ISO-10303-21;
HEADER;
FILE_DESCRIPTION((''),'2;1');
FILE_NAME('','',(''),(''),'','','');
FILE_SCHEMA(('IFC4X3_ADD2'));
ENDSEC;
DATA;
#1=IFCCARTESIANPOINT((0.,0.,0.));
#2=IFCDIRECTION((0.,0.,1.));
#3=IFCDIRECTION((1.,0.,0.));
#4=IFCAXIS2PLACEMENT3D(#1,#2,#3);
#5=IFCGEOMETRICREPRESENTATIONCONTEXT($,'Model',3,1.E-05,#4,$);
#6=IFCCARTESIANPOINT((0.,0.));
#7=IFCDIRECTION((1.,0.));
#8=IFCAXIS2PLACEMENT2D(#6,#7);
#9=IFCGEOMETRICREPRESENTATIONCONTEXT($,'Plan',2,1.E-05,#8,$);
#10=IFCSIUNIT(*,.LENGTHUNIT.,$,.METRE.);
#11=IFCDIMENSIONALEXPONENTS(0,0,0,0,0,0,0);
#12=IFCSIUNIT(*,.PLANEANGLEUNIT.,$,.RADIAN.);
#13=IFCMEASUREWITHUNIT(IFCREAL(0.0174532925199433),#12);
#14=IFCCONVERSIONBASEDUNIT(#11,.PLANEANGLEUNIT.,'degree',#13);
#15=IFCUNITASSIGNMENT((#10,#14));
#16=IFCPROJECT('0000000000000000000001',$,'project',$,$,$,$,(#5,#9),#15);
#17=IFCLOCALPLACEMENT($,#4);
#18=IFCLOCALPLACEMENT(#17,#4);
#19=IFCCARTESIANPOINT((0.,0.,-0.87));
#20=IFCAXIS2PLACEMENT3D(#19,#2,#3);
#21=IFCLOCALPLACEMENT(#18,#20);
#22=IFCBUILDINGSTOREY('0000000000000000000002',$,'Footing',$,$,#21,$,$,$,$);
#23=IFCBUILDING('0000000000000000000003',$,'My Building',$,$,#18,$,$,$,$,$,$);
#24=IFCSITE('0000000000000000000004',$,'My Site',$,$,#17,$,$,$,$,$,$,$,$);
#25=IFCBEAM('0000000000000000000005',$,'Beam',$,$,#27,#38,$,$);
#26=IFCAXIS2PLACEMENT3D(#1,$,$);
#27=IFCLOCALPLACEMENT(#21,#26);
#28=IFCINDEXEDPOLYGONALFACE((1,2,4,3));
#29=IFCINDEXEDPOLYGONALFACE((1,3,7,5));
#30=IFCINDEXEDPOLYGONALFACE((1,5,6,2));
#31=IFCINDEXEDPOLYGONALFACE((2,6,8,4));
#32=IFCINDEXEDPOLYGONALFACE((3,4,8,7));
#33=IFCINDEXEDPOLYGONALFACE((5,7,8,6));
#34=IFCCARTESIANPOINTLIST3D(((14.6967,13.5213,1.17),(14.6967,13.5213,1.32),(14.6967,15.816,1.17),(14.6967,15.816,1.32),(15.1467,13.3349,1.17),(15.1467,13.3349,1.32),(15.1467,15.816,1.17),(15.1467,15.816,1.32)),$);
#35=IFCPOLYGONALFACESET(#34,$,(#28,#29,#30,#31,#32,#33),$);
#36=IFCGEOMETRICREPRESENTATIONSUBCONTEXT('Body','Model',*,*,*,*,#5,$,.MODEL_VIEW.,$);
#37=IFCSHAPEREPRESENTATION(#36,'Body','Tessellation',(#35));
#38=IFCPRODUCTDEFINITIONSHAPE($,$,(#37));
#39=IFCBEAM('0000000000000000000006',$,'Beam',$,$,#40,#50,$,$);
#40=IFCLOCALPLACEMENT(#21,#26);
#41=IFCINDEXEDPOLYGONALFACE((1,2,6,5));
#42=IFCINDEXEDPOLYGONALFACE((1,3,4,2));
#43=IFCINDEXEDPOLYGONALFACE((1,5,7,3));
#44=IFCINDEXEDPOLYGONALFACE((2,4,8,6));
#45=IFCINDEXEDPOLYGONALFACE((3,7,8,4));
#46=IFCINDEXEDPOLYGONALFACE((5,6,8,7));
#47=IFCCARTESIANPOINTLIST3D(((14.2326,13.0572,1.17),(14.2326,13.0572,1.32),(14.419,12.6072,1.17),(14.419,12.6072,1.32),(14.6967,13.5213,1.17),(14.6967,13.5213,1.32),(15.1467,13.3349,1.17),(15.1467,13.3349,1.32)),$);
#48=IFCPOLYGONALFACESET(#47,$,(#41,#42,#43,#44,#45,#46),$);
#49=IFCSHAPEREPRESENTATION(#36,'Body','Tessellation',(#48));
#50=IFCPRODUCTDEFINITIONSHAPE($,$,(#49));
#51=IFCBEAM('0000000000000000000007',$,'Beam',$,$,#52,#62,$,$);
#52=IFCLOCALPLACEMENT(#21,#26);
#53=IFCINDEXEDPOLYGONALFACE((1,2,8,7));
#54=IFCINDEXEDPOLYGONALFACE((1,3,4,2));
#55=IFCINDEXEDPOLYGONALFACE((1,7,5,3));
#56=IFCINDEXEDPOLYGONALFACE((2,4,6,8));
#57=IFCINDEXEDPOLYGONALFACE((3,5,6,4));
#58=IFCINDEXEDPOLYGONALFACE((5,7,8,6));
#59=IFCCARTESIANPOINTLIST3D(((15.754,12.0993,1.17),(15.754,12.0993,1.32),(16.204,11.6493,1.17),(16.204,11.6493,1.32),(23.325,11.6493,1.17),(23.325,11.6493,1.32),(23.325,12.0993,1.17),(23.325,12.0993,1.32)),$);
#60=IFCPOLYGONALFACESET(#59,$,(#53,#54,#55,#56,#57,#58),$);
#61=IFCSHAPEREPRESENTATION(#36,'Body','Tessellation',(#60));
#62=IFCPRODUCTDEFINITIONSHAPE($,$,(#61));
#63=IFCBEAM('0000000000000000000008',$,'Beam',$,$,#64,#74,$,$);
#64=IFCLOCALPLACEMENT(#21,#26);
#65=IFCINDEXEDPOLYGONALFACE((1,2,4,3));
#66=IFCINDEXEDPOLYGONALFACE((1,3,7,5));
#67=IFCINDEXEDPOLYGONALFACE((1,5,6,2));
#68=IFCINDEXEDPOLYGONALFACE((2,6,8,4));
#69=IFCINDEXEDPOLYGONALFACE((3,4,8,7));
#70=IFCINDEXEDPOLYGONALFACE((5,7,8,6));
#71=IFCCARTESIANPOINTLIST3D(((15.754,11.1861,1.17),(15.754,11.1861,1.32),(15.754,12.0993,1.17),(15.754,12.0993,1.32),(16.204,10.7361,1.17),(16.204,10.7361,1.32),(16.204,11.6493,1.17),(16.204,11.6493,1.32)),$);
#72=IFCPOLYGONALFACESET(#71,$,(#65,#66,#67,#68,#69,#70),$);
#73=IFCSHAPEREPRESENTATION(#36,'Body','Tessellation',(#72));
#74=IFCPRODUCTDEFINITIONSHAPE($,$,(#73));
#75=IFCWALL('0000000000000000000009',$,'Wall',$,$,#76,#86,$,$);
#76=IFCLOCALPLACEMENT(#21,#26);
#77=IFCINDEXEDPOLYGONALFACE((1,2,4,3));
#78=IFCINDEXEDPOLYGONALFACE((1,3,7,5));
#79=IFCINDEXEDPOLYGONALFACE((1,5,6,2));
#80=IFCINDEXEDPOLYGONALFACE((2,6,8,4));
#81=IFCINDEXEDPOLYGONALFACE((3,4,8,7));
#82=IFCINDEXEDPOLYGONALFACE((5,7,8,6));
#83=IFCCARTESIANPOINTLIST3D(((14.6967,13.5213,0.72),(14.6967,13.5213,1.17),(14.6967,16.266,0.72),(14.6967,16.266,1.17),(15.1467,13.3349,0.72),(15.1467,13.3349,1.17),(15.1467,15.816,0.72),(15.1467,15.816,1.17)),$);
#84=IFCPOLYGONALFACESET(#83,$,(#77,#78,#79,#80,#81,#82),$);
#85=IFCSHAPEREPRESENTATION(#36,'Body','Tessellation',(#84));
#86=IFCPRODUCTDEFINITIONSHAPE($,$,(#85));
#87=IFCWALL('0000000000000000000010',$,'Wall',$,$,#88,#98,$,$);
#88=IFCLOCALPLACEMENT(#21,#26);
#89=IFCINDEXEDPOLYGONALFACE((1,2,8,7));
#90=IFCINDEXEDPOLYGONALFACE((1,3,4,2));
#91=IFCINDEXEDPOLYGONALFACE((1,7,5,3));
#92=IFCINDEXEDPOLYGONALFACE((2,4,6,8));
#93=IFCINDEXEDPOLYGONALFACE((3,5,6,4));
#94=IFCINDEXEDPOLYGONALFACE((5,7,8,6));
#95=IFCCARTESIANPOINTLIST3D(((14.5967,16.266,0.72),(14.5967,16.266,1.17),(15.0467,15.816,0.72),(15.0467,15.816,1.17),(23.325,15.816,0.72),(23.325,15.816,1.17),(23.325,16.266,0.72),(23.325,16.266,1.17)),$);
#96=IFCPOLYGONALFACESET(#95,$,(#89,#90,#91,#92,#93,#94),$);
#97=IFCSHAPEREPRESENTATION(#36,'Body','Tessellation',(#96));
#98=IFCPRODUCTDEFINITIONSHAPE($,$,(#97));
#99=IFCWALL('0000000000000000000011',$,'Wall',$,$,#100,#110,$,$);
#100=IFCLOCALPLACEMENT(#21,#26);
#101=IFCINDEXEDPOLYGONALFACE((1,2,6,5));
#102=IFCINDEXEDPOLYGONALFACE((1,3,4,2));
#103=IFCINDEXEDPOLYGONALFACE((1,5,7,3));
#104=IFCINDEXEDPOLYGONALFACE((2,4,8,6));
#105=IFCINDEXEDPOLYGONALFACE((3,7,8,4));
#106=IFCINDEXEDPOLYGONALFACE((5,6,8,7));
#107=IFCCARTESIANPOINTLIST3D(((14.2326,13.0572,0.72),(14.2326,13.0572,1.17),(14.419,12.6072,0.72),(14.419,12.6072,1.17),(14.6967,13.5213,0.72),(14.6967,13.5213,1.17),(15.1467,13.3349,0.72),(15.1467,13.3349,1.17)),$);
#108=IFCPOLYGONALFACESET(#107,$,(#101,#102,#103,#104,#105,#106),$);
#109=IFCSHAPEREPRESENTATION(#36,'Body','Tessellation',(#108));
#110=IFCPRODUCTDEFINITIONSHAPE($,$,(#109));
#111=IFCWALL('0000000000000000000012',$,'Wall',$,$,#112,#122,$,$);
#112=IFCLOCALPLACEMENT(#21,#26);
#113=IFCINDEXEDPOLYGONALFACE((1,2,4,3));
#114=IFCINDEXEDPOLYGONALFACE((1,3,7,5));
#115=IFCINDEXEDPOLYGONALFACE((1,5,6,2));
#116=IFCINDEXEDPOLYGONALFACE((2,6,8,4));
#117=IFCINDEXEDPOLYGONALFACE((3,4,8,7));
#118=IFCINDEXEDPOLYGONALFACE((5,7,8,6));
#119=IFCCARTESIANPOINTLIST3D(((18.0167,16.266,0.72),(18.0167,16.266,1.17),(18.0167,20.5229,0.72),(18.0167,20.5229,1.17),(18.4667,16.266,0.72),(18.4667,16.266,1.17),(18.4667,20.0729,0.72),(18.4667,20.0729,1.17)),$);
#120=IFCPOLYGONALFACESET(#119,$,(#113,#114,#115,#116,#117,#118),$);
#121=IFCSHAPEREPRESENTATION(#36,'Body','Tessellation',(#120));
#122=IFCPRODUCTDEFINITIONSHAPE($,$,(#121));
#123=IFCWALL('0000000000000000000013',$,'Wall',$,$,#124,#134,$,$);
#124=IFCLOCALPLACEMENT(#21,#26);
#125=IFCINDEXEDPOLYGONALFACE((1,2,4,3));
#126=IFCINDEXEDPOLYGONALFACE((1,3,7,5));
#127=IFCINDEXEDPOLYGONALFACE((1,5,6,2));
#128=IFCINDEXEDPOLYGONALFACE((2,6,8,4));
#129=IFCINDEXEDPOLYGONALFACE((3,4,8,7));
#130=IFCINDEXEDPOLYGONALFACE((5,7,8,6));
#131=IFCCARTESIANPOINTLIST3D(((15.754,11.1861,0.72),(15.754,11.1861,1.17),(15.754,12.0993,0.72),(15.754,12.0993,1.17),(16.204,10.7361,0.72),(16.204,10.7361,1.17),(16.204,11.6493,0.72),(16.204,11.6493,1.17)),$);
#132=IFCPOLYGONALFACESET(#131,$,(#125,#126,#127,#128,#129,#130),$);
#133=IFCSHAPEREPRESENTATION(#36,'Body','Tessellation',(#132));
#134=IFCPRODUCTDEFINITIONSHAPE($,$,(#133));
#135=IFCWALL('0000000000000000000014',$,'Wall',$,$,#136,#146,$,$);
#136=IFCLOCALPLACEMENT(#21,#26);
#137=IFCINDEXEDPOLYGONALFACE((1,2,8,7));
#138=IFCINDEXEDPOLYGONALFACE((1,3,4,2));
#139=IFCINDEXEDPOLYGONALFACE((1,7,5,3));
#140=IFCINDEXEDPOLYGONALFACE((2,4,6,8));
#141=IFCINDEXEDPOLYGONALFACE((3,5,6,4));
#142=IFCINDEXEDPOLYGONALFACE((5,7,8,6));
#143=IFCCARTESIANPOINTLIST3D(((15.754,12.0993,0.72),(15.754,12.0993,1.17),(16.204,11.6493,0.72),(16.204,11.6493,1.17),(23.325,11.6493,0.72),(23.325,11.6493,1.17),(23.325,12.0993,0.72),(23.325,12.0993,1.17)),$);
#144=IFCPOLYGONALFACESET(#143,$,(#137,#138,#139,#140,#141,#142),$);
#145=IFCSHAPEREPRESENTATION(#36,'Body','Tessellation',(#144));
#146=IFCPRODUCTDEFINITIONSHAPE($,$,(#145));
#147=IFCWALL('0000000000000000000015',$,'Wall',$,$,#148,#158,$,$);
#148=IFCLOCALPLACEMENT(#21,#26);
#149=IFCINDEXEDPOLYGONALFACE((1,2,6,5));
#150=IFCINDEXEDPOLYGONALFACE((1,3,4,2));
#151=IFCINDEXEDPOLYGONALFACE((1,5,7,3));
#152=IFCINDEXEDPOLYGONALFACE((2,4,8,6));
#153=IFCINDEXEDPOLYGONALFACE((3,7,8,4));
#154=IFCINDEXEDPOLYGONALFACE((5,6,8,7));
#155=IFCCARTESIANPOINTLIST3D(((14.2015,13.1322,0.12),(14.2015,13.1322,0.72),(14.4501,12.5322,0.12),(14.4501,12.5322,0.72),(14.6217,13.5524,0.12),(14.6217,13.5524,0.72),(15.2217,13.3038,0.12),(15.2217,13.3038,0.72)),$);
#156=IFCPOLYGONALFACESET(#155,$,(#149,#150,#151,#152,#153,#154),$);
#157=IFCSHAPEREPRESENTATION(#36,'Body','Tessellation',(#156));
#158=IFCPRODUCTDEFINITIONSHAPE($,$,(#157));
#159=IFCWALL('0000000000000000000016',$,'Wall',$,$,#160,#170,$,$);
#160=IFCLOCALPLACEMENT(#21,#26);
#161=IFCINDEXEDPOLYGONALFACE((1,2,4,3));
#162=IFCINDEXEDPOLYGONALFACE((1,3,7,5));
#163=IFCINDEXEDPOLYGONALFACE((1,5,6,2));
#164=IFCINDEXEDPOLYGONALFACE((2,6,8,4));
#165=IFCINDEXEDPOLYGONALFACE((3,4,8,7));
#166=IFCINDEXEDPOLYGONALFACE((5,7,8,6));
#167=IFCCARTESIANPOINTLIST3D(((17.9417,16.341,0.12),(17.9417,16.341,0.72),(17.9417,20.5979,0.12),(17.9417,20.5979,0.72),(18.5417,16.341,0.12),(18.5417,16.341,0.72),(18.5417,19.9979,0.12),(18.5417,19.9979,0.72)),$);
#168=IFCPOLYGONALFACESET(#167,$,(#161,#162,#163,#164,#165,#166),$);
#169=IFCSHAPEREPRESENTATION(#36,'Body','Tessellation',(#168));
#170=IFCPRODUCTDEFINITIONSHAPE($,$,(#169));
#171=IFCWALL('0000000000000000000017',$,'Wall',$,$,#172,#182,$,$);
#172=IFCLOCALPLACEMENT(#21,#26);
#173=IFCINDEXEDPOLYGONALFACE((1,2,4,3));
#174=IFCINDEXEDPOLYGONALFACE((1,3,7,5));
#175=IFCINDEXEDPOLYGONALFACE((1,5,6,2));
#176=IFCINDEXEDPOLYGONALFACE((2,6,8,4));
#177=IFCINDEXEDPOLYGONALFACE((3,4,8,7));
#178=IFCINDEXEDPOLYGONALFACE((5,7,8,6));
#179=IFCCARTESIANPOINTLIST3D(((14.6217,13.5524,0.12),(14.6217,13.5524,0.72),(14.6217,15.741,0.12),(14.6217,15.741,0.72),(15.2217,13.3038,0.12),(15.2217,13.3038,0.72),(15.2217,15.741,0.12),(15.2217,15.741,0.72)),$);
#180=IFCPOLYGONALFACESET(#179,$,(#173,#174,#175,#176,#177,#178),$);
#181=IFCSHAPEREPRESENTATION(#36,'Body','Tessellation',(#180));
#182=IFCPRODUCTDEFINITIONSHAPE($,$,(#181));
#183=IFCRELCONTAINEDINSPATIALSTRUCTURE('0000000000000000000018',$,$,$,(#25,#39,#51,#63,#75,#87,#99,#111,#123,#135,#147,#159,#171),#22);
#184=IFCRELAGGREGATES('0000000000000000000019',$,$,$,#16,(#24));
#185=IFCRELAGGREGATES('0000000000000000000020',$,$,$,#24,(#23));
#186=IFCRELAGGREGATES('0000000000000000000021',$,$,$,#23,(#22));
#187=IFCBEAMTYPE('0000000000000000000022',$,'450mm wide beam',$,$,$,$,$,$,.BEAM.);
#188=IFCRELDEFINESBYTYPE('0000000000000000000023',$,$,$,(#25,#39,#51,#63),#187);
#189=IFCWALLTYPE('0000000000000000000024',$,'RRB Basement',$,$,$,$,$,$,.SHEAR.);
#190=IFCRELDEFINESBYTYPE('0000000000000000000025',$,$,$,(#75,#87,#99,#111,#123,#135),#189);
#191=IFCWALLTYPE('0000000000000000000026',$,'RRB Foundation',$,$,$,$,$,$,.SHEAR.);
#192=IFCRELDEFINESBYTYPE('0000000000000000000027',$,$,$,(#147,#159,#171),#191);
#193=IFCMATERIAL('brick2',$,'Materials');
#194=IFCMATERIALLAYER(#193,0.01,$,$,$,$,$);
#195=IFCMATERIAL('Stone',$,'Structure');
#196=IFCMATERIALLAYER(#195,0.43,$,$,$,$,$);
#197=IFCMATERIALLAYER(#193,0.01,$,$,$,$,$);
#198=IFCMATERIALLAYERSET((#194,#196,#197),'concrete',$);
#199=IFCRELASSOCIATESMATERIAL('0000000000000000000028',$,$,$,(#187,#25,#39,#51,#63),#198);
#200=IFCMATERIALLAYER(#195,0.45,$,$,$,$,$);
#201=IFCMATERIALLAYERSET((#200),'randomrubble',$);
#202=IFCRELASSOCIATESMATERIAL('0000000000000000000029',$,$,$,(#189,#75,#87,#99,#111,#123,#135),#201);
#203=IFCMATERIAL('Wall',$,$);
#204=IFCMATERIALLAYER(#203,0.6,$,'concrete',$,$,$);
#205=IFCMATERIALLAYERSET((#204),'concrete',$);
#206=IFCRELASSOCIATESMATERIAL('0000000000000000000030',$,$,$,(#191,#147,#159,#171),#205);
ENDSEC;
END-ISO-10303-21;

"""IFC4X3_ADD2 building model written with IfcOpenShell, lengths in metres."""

from ifc_helpers import new_model, entity, si_unit, converted_unit, frame, origin_with_axes, origin_2d_with_axis, place, context, subcontext, project, spatial, line, indexed_curve, outline, extrude, material, layer, layer_set, layer_usage, type_object, element, save


model = new_model("IFC4X3_ADD2")

# Units and contexts
model_context = context("Model", 3, precision=1e-05, world=origin_with_axes())
plan_context = context("Plan", 2, precision=1e-05, world=origin_2d_with_axis())
body_context = subcontext(model_context, "Body", "Model", "MODEL_VIEW")
ifc_project = project(units=[si_unit("LENGTHUNIT", "METRE"), converted_unit("PLANEANGLEUNIT", "degree", entity("IfcReal", 0.0174532925199433), si_unit("PLANEANGLEUNIT", "RADIAN"), dimensions=[0, 0, 0, 0, 0, 0, 0])], contexts=[model_context, plan_context])

# Site, building, storey
site_placement = place(None, origin_with_axes())
site = spatial("IfcSite", under=ifc_project, at=site_placement, Name="My Site")
building_placement = place(site_placement, origin_with_axes())
building = spatial("IfcBuilding", under=site, at=building_placement, Name="My Building")
storey_placement = place(building_placement, frame((0.0, 0.0, -0.87), z_axis=(0.0, 0.0, 1.0), x_axis=(1.0, 0.0, 0.0)))
storey = spatial("IfcBuildingStorey", under=building, at=storey_placement, Name="Footing")

# Beams
ifc_material_1 = material(Name="brick2", Category="Materials")
ifc_layer_1 = layer(ifc_material_1, 0.01)
ifc_material_2 = material(Name="Stone", Category="Structure")
ifc_layer_2 = layer(ifc_material_2, 0.43)
ifc_layer_3 = layer(ifc_material_1, 0.01)
ifc_layer_set_1 = layer_set([ifc_layer_1, ifc_layer_2, ifc_layer_3], Name="concrete")
ifc_layer_usage_1 = layer_usage(ifc_layer_set_1, "AXIS2", "POSITIVE", 0.0)
beam_type = type_object("IfcBeamType", Name="450mm wide beam", PredefinedType="BEAM", material=ifc_layer_set_1)
beam_1_placement = place(storey_placement, frame((14.6967, 15.816, 1.17), z_axis=(0.0, 0.0, 1.0), x_axis=(0.0, -1.0, 0.0)))
element("IfcBeam", 1, at=beam_1_placement, inside=storey, type_object=beam_type, material=ifc_layer_usage_1, Name="Beam", context=body_context, shape_type="SweptSolid", body=[
    extrude(outline(indexed_curve([(0.0, 0.0), (0.0, 0.45), (2.4811, 0.45), (2.2947, 0.0)], segments=[line(1, 2, 3, 4, 1)])), origin_with_axes(), (0.0, 0.0, 1.0), 0.15),
])
ifc_layer_usage_2 = layer_usage(ifc_layer_set_1, "AXIS2", "POSITIVE", 0.0)
beam_2_placement = place(storey_placement, frame((14.6967, 13.5213, 1.17), z_axis=(0.0, 0.0, 1.0), x_axis=(-0.707107, -0.707107, 0.0)))
element("IfcBeam", 2, at=beam_2_placement, inside=storey, type_object=beam_type, material=ifc_layer_usage_2, Name="Beam", context=body_context, shape_type="SweptSolid", body=[
    extrude(outline(indexed_curve([(0.0, 0.0), (-0.1864, 0.45), (0.8427, 0.45), (0.6563, 0.0)], segments=[line(1, 2, 3, 4, 1)])), origin_with_axes(), (0.0, 0.0, 1.0), 0.15),
])
ifc_layer_usage_3 = layer_usage(ifc_layer_set_1, "AXIS2", "POSITIVE", 0.0)
beam_3_placement = place(storey_placement, frame((15.754, 11.6493, 1.17), z_axis=(0.0, 0.0, 1.0), x_axis=(1.0, 0.0, 0.0)))
element("IfcBeam", 3, at=beam_3_placement, inside=storey, type_object=beam_type, material=ifc_layer_usage_3, Name="Beam", context=body_context, shape_type="SweptSolid", body=[
    extrude(outline(indexed_curve([(0.45, 0.0), (0.0, 0.45), (7.571, 0.45), (7.571, 0.0)], segments=[line(1, 2, 3, 4, 1)])), origin_with_axes(), (0.0, 0.0, 1.0), 0.15),
])
ifc_layer_usage_4 = layer_usage(ifc_layer_set_1, "AXIS2", "POSITIVE", 0.0)
beam_4_placement = place(storey_placement, frame((15.754, 11.6493, 1.17), z_axis=(0.0, 0.0, 1.0), x_axis=(0.0, -1.0, 0.0)))
element("IfcBeam", 4, at=beam_4_placement, inside=storey, type_object=beam_type, material=ifc_layer_usage_4, Name="Beam", context=body_context, shape_type="SweptSolid", body=[
    extrude(outline(indexed_curve([(-0.45, 0.0), (0.0, 0.45), (0.9132, 0.45), (0.4632, 0.0)], segments=[line(1, 2, 3, 4, 1)])), origin_with_axes(), (0.0, 0.0, 1.0), 0.15),
])

# Walls
ifc_layer_4 = layer(ifc_material_2, 0.45)
ifc_layer_set_2 = layer_set([ifc_layer_4], Name="randomrubble")
ifc_layer_usage_5 = layer_usage(ifc_layer_set_2, "AXIS2", "POSITIVE", 0.0)
wall_type_1 = type_object("IfcWallType", Name="RRB Basement", PredefinedType="SHEAR", material=ifc_layer_set_2)
wall_1_placement = place(storey_placement, frame((15.1467, 13.3349, 0.72), z_axis=(0.0, 0.0, 1.0), x_axis=(0.0, 1.0, 0.0)))
element("IfcWall", 5, at=wall_1_placement, inside=storey, type_object=wall_type_1, material=ifc_layer_usage_5, Name="Wall", context=body_context, shape_type="SweptSolid", body=[
    extrude(outline(indexed_curve([(0.0, 0.0), (0.1864, 0.45), (2.9311, 0.45), (2.4811, 0.0)], segments=[line(1, 2, 3, 4, 1)])), origin_with_axes(), (0.0, 0.0, 1.0), 0.45),
])
ifc_layer_usage_6 = layer_usage(ifc_layer_set_2, "AXIS2", "POSITIVE", 0.0)
wall_2_placement = place(storey_placement, frame((15.0467, 15.816, 0.72), z_axis=(0.0, 0.0, 1.0), x_axis=(1.0, -0.000001, 0.0)))
element("IfcWall", 6, at=wall_2_placement, inside=storey, type_object=wall_type_1, material=ifc_layer_usage_6, Name="Wall", context=body_context, shape_type="SweptSolid", body=[
    extrude(outline(indexed_curve([(0.0, 0.0), (-0.45, 0.45), (8.2783, 0.45), (8.2783, 0.0)], segments=[line(1, 2, 3, 4, 1)])), origin_with_axes(), (0.0, 0.0, 1.0), 0.45),
])
ifc_layer_usage_7 = layer_usage(ifc_layer_set_2, "AXIS2", "POSITIVE", 0.0)
wall_3_placement = place(storey_placement, frame((14.419, 12.6072, 0.72), z_axis=(0.0, 0.0, 1.0), x_axis=(0.707107, 0.707107, 0.0)))
element("IfcWall", 7, at=wall_3_placement, inside=storey, type_object=wall_type_1, material=ifc_layer_usage_7, Name="Wall", context=body_context, shape_type="SweptSolid", body=[
    extrude(outline(indexed_curve([(0.0, 0.0), (0.1864, 0.45), (0.8427, 0.45), (1.0291, 0.0)], segments=[line(1, 2, 3, 4, 1)])), origin_with_axes(), (0.0, 0.0, 1.0), 0.45),
])
ifc_layer_usage_8 = layer_usage(ifc_layer_set_2, "AXIS2", "POSITIVE", 0.0)
wall_4_placement = place(storey_placement, frame((18.4667, 15.816, 0.72), z_axis=(0.0, 0.0, 1.0), x_axis=(0.0, 1.0, 0.0)))
element("IfcWall", 8, at=wall_4_placement, inside=storey, type_object=wall_type_1, material=ifc_layer_usage_8, Name="Wall", context=body_context, shape_type="SweptSolid", body=[
    extrude(outline(indexed_curve([(0.45, 0.0), (0.45, 0.45), (4.7069, 0.45), (4.2569, 0.0)], segments=[line(1, 2, 3, 4, 1)])), origin_with_axes(), (0.0, 0.0, 1.0), 0.45),
])
ifc_layer_usage_9 = layer_usage(ifc_layer_set_2, "AXIS2", "POSITIVE", 0.0)
wall_5_placement = place(storey_placement, frame((16.204, 10.7361, 0.72), z_axis=(0.0, 0.0, 1.0), x_axis=(0.000001, 1.0, 0.0)))
element("IfcWall", 9, at=wall_5_placement, inside=storey, type_object=wall_type_1, material=ifc_layer_usage_9, Name="Wall", context=body_context, shape_type="SweptSolid", body=[
    extrude(outline(indexed_curve([(0.0, 0.0), (0.45, 0.45), (1.3632, 0.45), (0.9132, 0.0)], segments=[line(1, 2, 3, 4, 1)])), origin_with_axes(), (0.0, 0.0, 1.0), 0.45),
])
ifc_layer_usage_10 = layer_usage(ifc_layer_set_2, "AXIS2", "POSITIVE", 0.0)
wall_6_placement = place(storey_placement, frame((16.204, 11.6493, 0.72), z_axis=(0.0, 0.0, 1.0), x_axis=(1.0, -0.000001, 0.0)))
element("IfcWall", 10, at=wall_6_placement, inside=storey, type_object=wall_type_1, material=ifc_layer_usage_10, Name="Wall", context=body_context, shape_type="SweptSolid", body=[
    extrude(outline(indexed_curve([(0.0, 0.0), (-0.45, 0.45), (7.121, 0.45), (7.121, 0.0)], segments=[line(1, 2, 3, 4, 1)])), origin_with_axes(), (0.0, 0.0, 1.0), 0.45),
])
ifc_material_3 = material(Name="Wall")
ifc_layer_5 = layer(ifc_material_3, 0.6, Name="concrete")
ifc_layer_set_3 = layer_set([ifc_layer_5], Name="concrete")
ifc_layer_usage_11 = layer_usage(ifc_layer_set_3, "AXIS2", "POSITIVE", 0.0)
wall_type_2 = type_object("IfcWallType", Name="RRB Foundation", PredefinedType="SHEAR", material=ifc_layer_set_3)
wall_7_placement = place(storey_placement, frame((14.4501, 12.5322, 0.12), z_axis=(0.0, 0.0, 1.0), x_axis=(0.707107, 0.707107, 0.0)))
element("IfcWall", 11, at=wall_7_placement, inside=storey, type_object=wall_type_2, material=ifc_layer_usage_11, Name="Wall", context=body_context, shape_type="SweptSolid", body=[
    extrude(outline(indexed_curve([(0.0, 0.0), (0.2485, 0.6), (0.8427, 0.6), (1.0912, 0.0)], segments=[line(1, 2, 3, 4, 1)])), origin_with_axes(), (0.0, 0.0, 1.0), 0.6),
])
ifc_layer_usage_12 = layer_usage(ifc_layer_set_3, "AXIS2", "POSITIVE", 0.0)
wall_8_placement = place(storey_placement, frame((18.5417, 15.741, 0.12), z_axis=(0.0, 0.0, 1.0), x_axis=(0.0, 1.0, 0.0)))
element("IfcWall", 12, at=wall_8_placement, inside=storey, type_object=wall_type_2, material=ifc_layer_usage_12, Name="Wall", context=body_context, shape_type="SweptSolid", body=[
    extrude(outline(indexed_curve([(0.6, 0.0), (0.6, 0.6), (4.8569, 0.6), (4.2569, 0.0)], segments=[line(1, 2, 3, 4, 1)])), origin_with_axes(), (0.0, 0.0, 1.0), 0.6),
])
ifc_layer_usage_13 = layer_usage(ifc_layer_set_3, "AXIS2", "POSITIVE", 0.0)
wall_9_placement = place(storey_placement, frame((15.2217, 13.3038, 0.12), z_axis=(0.0, 0.0, 1.0), x_axis=(0.0, 1.0, 0.0)))
element("IfcWall", 13, at=wall_9_placement, inside=storey, type_object=wall_type_2, material=ifc_layer_usage_13, Name="Wall", context=body_context, shape_type="SweptSolid", body=[
    extrude(outline(indexed_curve([(0.0, 0.0), (0.2485, 0.6), (2.4372, 0.6), (2.4372, 0.0)], segments=[line(1, 2, 3, 4, 1)])), origin_with_axes(), (0.0, 0.0, 1.0), 0.6),
])

save(model, "model.ifc")
